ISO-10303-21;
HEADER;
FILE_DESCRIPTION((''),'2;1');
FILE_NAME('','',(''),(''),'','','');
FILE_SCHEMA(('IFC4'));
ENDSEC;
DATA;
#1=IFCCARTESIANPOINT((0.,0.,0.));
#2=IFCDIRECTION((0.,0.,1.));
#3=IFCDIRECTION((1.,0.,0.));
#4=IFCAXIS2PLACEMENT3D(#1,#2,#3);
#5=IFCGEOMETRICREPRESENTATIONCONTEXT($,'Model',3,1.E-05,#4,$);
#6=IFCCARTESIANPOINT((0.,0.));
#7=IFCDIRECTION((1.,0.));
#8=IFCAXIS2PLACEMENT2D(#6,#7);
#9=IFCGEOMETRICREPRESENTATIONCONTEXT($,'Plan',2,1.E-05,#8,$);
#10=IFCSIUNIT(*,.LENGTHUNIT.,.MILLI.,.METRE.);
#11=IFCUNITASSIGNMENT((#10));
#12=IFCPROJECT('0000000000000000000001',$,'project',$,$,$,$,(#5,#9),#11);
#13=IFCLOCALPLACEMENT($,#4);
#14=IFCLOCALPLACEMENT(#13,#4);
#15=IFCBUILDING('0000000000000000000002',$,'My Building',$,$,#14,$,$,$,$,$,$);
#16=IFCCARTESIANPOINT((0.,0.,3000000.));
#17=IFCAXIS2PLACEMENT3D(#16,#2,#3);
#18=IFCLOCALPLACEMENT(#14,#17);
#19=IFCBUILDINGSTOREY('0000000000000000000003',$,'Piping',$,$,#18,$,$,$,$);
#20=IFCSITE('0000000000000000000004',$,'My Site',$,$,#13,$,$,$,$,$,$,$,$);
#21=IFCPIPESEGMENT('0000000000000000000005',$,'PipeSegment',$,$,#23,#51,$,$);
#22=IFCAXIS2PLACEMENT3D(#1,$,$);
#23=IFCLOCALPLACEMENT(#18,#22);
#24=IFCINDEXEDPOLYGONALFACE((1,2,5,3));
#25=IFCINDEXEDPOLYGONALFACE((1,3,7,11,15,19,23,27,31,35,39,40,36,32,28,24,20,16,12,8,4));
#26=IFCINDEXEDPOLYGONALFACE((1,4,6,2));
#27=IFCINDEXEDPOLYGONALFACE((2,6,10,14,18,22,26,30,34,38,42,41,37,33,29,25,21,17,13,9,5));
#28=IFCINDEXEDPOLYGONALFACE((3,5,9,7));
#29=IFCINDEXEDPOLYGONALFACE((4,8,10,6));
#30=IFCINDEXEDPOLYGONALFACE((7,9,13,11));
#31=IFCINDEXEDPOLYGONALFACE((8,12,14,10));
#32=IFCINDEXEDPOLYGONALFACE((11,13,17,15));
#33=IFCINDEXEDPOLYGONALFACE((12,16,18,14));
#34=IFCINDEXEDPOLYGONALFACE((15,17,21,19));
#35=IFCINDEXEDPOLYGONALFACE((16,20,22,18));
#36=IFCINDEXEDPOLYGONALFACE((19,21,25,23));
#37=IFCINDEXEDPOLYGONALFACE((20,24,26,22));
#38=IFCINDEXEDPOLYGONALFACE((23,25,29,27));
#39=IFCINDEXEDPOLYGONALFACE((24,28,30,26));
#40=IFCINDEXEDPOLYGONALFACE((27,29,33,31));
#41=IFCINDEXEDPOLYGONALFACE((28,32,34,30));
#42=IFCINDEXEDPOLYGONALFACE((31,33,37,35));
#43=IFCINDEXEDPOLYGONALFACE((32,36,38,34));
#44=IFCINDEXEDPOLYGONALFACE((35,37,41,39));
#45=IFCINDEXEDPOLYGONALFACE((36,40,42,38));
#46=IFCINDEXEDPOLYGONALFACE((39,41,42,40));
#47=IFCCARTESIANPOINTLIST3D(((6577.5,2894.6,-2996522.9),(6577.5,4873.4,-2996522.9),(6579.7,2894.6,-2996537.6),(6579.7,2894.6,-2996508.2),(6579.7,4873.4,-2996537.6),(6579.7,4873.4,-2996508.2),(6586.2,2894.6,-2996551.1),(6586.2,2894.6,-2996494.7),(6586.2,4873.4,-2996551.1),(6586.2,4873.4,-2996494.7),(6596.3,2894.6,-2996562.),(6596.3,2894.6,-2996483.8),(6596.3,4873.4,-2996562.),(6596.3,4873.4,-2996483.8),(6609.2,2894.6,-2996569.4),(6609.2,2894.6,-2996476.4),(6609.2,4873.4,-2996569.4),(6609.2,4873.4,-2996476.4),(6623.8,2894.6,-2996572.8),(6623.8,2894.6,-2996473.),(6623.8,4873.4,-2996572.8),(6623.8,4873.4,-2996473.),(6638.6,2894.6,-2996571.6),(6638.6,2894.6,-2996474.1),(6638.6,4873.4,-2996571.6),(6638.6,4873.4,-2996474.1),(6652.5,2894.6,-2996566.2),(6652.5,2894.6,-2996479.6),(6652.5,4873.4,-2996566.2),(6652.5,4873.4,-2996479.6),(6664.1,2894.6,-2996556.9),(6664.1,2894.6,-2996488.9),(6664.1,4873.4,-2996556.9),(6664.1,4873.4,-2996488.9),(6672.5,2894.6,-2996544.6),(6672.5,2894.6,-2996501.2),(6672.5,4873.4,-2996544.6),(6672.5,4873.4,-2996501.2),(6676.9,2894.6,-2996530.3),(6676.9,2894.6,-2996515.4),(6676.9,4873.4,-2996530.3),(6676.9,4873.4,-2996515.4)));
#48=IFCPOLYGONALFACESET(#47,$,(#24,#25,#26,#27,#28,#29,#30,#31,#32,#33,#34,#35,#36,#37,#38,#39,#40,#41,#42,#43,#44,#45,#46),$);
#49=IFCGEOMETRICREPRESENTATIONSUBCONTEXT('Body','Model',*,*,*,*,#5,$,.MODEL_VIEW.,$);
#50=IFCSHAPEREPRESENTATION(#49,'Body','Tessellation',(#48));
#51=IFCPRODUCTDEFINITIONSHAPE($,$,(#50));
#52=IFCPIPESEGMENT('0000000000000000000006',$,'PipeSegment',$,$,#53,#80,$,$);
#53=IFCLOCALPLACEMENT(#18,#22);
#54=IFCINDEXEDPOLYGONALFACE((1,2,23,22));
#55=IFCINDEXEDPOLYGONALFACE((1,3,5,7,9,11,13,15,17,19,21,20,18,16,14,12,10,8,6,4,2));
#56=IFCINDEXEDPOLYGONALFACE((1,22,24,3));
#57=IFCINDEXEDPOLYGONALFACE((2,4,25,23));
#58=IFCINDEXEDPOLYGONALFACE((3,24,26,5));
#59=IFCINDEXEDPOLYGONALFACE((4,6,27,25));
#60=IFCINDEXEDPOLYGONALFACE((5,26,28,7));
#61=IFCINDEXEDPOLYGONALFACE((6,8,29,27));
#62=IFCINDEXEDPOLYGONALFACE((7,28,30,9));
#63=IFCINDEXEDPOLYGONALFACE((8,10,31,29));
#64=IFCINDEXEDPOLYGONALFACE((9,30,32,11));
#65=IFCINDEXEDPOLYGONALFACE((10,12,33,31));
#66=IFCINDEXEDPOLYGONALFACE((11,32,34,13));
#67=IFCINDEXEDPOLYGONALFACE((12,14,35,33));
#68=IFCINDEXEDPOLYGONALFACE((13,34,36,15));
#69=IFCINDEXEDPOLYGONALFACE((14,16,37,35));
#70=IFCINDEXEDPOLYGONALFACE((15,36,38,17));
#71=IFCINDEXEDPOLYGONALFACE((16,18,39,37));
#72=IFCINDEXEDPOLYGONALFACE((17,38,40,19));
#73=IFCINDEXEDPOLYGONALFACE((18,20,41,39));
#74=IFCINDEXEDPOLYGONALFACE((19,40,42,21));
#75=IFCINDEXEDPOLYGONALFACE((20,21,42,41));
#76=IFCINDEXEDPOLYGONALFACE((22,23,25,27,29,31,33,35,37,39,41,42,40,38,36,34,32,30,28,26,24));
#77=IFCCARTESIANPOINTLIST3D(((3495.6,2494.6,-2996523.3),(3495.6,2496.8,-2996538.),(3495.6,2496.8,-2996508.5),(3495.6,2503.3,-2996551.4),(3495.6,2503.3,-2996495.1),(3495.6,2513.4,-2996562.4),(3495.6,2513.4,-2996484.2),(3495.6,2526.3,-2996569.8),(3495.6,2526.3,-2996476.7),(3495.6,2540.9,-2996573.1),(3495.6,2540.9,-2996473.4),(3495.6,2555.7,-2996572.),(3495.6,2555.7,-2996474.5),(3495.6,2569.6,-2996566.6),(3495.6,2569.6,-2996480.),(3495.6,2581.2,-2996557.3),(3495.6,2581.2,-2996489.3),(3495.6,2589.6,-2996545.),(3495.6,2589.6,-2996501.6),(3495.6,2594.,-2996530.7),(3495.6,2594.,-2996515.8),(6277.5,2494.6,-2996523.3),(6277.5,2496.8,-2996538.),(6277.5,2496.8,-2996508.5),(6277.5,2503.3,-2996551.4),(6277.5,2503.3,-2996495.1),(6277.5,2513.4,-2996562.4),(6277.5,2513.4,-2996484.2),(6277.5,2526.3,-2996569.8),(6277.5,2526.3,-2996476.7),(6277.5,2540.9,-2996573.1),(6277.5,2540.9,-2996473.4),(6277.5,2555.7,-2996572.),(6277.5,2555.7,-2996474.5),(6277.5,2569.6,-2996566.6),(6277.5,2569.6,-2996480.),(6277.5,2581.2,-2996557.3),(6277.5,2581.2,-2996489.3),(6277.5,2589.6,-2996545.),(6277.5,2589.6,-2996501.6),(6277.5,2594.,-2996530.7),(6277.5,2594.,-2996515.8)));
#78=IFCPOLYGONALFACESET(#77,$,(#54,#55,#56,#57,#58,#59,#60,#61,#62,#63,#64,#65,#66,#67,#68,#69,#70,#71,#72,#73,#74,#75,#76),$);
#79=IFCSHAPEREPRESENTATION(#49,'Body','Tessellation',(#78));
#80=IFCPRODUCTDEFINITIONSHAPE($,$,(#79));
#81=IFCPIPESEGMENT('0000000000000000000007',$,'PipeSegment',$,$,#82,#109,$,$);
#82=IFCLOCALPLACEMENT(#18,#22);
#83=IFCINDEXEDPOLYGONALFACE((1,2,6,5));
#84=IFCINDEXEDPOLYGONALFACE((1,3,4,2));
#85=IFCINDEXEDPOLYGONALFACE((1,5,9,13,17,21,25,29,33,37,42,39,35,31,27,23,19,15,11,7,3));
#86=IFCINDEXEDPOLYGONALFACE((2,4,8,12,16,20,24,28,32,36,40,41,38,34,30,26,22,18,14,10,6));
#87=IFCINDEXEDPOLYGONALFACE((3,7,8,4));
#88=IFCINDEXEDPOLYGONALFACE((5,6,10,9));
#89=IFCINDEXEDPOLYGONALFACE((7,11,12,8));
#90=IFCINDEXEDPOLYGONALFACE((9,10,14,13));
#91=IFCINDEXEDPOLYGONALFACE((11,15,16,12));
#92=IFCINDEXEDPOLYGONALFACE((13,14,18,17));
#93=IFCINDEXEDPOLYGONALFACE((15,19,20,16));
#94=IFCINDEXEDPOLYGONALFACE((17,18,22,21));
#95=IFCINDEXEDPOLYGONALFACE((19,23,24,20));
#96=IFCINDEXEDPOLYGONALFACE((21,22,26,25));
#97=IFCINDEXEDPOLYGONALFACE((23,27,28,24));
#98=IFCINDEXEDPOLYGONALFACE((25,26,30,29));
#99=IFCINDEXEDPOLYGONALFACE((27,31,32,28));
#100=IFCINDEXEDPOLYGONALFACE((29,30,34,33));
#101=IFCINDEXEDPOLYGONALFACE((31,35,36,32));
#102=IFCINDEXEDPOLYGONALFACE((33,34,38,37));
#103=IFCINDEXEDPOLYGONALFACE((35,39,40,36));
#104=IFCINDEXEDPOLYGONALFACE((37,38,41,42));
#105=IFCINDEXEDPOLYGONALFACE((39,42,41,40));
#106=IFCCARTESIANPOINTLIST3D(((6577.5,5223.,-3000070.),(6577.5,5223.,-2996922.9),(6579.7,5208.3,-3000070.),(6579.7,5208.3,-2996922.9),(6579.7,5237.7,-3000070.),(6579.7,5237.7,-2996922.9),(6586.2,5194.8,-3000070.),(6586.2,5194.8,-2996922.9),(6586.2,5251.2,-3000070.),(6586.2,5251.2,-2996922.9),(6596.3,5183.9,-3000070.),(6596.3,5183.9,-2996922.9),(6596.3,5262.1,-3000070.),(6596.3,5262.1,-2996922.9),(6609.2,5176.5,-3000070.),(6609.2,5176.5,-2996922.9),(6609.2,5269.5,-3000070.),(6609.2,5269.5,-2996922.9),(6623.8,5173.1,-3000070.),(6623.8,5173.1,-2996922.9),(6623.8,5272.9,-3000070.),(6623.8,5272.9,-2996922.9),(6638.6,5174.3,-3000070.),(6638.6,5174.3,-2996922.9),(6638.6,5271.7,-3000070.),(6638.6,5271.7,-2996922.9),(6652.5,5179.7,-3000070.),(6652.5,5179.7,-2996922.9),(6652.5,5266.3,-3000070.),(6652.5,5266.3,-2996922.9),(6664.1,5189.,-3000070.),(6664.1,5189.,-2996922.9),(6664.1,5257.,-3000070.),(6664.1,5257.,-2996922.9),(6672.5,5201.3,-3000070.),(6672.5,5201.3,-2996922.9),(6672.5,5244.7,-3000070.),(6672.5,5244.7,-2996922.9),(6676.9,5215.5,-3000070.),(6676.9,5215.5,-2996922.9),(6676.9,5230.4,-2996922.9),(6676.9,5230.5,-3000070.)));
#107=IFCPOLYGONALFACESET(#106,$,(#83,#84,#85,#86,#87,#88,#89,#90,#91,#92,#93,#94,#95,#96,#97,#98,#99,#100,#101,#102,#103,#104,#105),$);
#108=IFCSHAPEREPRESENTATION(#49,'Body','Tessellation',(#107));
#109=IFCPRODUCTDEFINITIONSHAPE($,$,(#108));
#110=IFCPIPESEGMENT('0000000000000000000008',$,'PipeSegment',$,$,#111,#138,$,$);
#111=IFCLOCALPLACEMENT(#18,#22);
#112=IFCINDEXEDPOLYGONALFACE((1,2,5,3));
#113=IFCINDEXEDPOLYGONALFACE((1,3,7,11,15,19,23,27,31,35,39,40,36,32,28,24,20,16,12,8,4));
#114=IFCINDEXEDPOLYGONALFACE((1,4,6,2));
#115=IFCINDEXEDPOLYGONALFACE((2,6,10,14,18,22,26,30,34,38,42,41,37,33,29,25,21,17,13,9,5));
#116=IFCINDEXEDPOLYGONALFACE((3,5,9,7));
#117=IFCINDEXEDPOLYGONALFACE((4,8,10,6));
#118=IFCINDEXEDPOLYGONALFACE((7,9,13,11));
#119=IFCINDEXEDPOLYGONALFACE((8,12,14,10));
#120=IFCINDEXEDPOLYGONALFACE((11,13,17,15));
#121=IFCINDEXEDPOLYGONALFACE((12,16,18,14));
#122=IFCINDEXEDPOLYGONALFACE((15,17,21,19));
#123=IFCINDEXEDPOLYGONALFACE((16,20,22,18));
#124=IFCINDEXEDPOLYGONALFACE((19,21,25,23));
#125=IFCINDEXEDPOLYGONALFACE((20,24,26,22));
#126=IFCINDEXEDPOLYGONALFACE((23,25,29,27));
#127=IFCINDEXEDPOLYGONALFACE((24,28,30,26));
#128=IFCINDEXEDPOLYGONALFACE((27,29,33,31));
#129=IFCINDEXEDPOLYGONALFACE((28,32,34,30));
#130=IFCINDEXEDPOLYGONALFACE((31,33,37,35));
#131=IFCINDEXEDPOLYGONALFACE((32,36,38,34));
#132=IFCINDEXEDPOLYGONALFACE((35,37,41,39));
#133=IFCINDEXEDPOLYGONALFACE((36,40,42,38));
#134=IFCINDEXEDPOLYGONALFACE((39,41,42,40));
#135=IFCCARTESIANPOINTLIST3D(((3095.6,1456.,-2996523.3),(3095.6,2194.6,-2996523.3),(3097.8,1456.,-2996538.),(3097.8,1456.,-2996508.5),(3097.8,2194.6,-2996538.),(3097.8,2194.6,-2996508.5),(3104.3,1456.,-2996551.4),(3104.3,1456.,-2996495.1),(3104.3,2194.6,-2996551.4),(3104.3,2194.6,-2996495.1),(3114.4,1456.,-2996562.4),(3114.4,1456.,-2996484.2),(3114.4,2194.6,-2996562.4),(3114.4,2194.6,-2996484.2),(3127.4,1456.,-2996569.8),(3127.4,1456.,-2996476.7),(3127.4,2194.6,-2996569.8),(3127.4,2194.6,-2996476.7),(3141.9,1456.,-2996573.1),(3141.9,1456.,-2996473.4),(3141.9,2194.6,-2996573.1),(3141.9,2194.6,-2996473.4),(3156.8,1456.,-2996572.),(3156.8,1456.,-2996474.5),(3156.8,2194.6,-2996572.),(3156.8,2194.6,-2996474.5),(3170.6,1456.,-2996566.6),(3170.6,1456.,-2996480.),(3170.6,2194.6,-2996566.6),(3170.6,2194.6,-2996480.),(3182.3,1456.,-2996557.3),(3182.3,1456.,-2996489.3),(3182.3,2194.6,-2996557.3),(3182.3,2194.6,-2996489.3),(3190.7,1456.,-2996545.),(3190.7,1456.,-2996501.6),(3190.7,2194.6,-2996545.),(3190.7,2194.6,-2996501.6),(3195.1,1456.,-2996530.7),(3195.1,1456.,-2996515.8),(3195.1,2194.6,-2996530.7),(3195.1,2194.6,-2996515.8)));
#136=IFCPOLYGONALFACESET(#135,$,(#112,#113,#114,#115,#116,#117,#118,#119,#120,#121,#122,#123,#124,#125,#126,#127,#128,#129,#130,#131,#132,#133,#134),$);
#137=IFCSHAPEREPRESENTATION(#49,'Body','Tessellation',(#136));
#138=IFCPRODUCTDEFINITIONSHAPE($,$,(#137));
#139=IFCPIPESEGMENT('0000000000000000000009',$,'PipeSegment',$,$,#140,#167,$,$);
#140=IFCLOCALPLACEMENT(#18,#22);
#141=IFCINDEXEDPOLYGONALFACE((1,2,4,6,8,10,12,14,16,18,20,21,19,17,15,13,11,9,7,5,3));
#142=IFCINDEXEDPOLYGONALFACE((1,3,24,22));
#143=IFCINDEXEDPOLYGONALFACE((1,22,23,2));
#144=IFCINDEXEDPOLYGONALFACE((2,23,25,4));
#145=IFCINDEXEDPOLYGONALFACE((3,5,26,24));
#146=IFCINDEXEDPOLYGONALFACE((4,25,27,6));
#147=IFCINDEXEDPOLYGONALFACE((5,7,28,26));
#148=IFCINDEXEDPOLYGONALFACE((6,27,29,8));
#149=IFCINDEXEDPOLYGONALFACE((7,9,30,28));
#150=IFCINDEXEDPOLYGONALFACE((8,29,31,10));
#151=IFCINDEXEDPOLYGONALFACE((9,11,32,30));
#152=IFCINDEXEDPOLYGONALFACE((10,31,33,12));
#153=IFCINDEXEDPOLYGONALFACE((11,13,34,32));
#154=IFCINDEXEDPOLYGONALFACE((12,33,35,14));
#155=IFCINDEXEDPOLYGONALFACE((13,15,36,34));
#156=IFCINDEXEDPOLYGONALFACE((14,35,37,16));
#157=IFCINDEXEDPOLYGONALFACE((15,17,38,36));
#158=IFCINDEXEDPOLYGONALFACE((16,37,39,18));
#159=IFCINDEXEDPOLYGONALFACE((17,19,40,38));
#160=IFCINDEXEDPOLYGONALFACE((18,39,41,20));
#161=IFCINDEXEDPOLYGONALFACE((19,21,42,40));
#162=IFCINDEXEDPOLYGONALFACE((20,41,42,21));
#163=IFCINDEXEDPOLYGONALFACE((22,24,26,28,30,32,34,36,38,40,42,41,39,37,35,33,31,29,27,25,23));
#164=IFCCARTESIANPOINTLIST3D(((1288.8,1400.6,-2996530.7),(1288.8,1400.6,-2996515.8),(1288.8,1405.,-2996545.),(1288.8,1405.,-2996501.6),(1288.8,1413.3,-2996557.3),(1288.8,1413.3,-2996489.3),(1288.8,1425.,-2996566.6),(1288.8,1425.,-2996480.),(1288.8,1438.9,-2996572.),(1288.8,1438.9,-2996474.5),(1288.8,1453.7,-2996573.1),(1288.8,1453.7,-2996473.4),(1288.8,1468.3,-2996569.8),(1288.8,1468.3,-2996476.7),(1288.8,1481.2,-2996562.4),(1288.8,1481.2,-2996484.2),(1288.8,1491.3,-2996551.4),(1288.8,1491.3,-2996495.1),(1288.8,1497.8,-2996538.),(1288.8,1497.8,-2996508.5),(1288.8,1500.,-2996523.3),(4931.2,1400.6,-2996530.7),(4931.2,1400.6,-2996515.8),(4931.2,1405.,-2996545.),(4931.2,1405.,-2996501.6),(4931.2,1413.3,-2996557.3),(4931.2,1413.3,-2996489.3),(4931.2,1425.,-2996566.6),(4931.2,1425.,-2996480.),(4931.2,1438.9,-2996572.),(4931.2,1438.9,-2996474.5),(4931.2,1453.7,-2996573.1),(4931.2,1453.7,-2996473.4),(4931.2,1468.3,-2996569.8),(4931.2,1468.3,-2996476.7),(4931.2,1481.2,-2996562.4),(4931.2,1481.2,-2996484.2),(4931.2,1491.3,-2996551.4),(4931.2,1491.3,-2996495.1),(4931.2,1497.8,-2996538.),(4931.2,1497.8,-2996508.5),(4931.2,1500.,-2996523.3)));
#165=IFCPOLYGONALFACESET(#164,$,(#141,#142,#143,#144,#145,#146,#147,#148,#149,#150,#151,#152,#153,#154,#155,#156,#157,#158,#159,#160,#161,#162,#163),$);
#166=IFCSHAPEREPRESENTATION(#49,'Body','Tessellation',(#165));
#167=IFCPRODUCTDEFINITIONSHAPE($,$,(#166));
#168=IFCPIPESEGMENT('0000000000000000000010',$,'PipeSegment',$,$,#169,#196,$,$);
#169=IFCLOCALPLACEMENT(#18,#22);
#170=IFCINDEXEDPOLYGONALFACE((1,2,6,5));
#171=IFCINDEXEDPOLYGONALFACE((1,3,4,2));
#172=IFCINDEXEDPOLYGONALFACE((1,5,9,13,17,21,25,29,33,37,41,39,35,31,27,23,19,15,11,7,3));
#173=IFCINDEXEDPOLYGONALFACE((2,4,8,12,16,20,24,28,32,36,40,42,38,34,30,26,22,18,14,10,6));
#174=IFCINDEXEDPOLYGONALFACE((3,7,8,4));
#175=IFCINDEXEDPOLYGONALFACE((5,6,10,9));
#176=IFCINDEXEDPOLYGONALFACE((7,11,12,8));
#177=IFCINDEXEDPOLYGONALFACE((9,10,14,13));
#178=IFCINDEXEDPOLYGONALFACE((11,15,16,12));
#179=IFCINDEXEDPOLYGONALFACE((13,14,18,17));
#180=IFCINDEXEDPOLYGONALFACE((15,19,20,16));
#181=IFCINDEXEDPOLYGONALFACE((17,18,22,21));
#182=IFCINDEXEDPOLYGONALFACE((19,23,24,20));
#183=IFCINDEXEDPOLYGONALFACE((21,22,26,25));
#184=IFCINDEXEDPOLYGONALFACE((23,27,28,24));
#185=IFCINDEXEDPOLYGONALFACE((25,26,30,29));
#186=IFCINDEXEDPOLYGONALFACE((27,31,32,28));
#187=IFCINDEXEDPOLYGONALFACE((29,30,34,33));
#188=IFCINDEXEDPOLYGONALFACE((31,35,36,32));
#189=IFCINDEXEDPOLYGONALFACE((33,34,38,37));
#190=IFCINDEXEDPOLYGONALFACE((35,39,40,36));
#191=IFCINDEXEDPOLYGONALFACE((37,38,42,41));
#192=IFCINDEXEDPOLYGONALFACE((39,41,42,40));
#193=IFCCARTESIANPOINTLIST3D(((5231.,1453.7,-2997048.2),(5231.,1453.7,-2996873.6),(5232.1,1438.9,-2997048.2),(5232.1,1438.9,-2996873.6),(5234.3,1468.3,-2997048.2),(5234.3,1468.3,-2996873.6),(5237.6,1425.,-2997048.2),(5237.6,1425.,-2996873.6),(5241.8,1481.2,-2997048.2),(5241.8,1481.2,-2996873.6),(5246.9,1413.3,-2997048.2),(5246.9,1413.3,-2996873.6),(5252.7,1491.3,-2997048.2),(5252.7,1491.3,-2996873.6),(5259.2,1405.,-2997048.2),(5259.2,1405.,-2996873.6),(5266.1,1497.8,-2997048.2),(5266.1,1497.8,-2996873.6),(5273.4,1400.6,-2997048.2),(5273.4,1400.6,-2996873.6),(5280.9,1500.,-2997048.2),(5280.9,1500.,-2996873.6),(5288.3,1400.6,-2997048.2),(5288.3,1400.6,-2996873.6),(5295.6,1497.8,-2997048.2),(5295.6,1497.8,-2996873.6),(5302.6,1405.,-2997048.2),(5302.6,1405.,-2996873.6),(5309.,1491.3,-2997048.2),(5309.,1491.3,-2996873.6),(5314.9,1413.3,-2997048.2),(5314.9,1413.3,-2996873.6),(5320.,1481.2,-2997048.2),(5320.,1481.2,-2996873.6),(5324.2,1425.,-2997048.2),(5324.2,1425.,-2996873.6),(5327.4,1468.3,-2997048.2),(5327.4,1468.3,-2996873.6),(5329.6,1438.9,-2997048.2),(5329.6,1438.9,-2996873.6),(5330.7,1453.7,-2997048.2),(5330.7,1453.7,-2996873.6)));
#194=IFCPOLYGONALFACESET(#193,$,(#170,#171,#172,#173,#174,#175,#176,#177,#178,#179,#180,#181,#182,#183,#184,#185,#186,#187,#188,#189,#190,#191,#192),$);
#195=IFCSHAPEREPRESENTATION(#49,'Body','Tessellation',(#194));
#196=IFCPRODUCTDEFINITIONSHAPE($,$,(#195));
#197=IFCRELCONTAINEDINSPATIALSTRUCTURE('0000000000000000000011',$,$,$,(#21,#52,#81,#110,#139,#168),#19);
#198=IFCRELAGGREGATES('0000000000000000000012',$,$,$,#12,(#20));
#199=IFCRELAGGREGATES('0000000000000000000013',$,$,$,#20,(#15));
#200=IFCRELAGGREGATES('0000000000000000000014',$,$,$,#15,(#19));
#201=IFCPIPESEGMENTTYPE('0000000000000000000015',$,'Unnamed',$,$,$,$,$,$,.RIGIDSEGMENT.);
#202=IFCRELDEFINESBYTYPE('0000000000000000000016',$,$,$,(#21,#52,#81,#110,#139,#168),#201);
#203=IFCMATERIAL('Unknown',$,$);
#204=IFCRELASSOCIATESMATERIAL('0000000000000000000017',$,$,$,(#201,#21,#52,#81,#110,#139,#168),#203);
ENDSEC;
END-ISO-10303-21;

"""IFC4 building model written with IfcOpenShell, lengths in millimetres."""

from ifc_helpers import new_model, si_unit, frame, origin_with_axes, origin_2d_with_axis, place, context, subcontext, project, spatial, circle, extrude, material, material_profile, profile_set, profile_usage, type_object, element, save


model = new_model("IFC4")

# Units and contexts
model_context = context("Model", 3, precision=1e-05, world=origin_with_axes())
plan_context = context("Plan", 2, precision=1e-05, world=origin_2d_with_axis())
body_context = subcontext(model_context, "Body", "Model", "MODEL_VIEW")
ifc_project = project(units=[si_unit("LENGTHUNIT", "METRE", prefix="MILLI")], contexts=[model_context, plan_context])

# Site, building, storey
site_placement = place(None, origin_with_axes())
site = spatial("IfcSite", under=ifc_project, at=site_placement, Name="My Site")
building_placement = place(site_placement, origin_with_axes())
building = spatial("IfcBuilding", under=site, at=building_placement, Name="My Building")
storey_placement = place(building_placement, frame((0.0, 0.0, 3000000.0), z_axis=(0.0, 0.0, 1.0), x_axis=(1.0, 0.0, 0.0)))
storey = spatial("IfcBuildingStorey", under=building, at=storey_placement, Name="Piping")

# Pipe segments
ifc_material = material(Name="Unknown")
ifc_material_profile_1 = material_profile(ifc_material, circle(Radius=50.0))
ifc_profile_set_1 = profile_set([ifc_material_profile_1])
ifc_profile_usage_1 = profile_usage(ifc_profile_set_1, cardinal=1)
pipe_segment_type = type_object("IfcPipeSegmentType", Name="Unnamed", PredefinedType="RIGIDSEGMENT", material=ifc_profile_set_1)
pipe_segment_1_placement = place(storey_placement, frame((6577.5, 2894.6, -2996572.9), z_axis=(0.0, 1.0, 0.0), x_axis=(-1.0, 0.0, 0.0)))
element("IfcPipeSegment", 1, at=pipe_segment_1_placement, inside=storey, type_object=pipe_segment_type, material=ifc_profile_usage_1, Name="PipeSegment", context=body_context, shape_type="SweptSolid", body=[
    extrude(circle(Radius=50.0), frame((-50.0, 50.0, 0.0), z_axis=(0.0, 0.0, 1.0), x_axis=(1.0, 0.0, 0.0)), (0.0, 0.0, 1.0), 1978.8),
])
ifc_profile_usage_2 = profile_usage(ifc_profile_set_1, cardinal=1)
pipe_segment_2_placement = place(storey_placement, frame((6277.5, 2494.6, -2996573.3), z_axis=(-1.0, 0.0, 0.0), x_axis=(0.0, -1.0, 0.0)))
element("IfcPipeSegment", 2, at=pipe_segment_2_placement, inside=storey, type_object=pipe_segment_type, material=ifc_profile_usage_2, Name="PipeSegment", context=body_context, shape_type="SweptSolid", body=[
    extrude(circle(Radius=50.0), frame((-50.0, 50.0, 0.0), z_axis=(0.0, 0.0, 1.0), x_axis=(1.0, 0.0, 0.0)), (0.0, 0.0, 1.0), 2781.9),
])
ifc_profile_usage_3 = profile_usage(ifc_profile_set_1, cardinal=1)
pipe_segment_3_placement = place(storey_placement, frame((6577.5, 5173.0, -2996922.9), z_axis=(0.0, 0.0, -1.0), x_axis=(-1.0, 0.0, 0.0)))
element("IfcPipeSegment", 3, at=pipe_segment_3_placement, inside=storey, type_object=pipe_segment_type, material=ifc_profile_usage_3, Name="PipeSegment", context=body_context, shape_type="SweptSolid", body=[
    extrude(circle(Radius=50.0), frame((-50.0, 50.0, 0.0), z_axis=(0.0, 0.0, 1.0), x_axis=(1.0, 0.0, 0.0)), (0.0, 0.0, 1.0), 3147.1),
])
ifc_profile_usage_4 = profile_usage(ifc_profile_set_1, cardinal=1)
pipe_segment_4_placement = place(storey_placement, frame((3095.6, 1456.0, -2996573.3), z_axis=(0.0, 1.0, 0.0), x_axis=(-1.0, 0.0, 0.0)))
element("IfcPipeSegment", 4, at=pipe_segment_4_placement, inside=storey, type_object=pipe_segment_type, material=ifc_profile_usage_4, Name="PipeSegment", context=body_context, shape_type="SweptSolid", body=[
    extrude(circle(Radius=50.0), frame((-50.0, 50.0, 0.0), z_axis=(0.0, 0.0, 1.0), x_axis=(1.0, 0.0, 0.0)), (0.0, 0.0, 1.0), 738.6),
])
ifc_profile_usage_5 = profile_usage(ifc_profile_set_1, cardinal=1)
pipe_segment_5_placement = place(storey_placement, frame((1288.8, 1500.0, -2996573.3), z_axis=(1.0, 0.0, 0.0), x_axis=(0.0, 1.0, 0.0)))
element("IfcPipeSegment", 5, at=pipe_segment_5_placement, inside=storey, type_object=pipe_segment_type, material=ifc_profile_usage_5, Name="PipeSegment", context=body_context, shape_type="SweptSolid", body=[
    extrude(circle(Radius=50.0), frame((-50.0, 50.0, 0.0), z_axis=(0.0, 0.0, 1.0), x_axis=(1.0, 0.0, 0.0)), (0.0, 0.0, 1.0), 3642.5),
])
ifc_profile_usage_6 = profile_usage(ifc_profile_set_1, cardinal=1)
pipe_segment_6_placement = place(storey_placement, frame((5230.9, 1500.0, -2996873.6), z_axis=(0.0, 0.0, -1.0), x_axis=(0.0, 1.0, 0.0)))
element("IfcPipeSegment", 6, at=pipe_segment_6_placement, inside=storey, type_object=pipe_segment_type, material=ifc_profile_usage_6, Name="PipeSegment", context=body_context, shape_type="SweptSolid", body=[
    extrude(circle(Radius=50.0), frame((-50.0, 50.0, 0.0), z_axis=(0.0, 0.0, 1.0), x_axis=(1.0, 0.0, 0.0)), (0.0, 0.0, 1.0), 174.5),
])

save(model, "model.ifc")
